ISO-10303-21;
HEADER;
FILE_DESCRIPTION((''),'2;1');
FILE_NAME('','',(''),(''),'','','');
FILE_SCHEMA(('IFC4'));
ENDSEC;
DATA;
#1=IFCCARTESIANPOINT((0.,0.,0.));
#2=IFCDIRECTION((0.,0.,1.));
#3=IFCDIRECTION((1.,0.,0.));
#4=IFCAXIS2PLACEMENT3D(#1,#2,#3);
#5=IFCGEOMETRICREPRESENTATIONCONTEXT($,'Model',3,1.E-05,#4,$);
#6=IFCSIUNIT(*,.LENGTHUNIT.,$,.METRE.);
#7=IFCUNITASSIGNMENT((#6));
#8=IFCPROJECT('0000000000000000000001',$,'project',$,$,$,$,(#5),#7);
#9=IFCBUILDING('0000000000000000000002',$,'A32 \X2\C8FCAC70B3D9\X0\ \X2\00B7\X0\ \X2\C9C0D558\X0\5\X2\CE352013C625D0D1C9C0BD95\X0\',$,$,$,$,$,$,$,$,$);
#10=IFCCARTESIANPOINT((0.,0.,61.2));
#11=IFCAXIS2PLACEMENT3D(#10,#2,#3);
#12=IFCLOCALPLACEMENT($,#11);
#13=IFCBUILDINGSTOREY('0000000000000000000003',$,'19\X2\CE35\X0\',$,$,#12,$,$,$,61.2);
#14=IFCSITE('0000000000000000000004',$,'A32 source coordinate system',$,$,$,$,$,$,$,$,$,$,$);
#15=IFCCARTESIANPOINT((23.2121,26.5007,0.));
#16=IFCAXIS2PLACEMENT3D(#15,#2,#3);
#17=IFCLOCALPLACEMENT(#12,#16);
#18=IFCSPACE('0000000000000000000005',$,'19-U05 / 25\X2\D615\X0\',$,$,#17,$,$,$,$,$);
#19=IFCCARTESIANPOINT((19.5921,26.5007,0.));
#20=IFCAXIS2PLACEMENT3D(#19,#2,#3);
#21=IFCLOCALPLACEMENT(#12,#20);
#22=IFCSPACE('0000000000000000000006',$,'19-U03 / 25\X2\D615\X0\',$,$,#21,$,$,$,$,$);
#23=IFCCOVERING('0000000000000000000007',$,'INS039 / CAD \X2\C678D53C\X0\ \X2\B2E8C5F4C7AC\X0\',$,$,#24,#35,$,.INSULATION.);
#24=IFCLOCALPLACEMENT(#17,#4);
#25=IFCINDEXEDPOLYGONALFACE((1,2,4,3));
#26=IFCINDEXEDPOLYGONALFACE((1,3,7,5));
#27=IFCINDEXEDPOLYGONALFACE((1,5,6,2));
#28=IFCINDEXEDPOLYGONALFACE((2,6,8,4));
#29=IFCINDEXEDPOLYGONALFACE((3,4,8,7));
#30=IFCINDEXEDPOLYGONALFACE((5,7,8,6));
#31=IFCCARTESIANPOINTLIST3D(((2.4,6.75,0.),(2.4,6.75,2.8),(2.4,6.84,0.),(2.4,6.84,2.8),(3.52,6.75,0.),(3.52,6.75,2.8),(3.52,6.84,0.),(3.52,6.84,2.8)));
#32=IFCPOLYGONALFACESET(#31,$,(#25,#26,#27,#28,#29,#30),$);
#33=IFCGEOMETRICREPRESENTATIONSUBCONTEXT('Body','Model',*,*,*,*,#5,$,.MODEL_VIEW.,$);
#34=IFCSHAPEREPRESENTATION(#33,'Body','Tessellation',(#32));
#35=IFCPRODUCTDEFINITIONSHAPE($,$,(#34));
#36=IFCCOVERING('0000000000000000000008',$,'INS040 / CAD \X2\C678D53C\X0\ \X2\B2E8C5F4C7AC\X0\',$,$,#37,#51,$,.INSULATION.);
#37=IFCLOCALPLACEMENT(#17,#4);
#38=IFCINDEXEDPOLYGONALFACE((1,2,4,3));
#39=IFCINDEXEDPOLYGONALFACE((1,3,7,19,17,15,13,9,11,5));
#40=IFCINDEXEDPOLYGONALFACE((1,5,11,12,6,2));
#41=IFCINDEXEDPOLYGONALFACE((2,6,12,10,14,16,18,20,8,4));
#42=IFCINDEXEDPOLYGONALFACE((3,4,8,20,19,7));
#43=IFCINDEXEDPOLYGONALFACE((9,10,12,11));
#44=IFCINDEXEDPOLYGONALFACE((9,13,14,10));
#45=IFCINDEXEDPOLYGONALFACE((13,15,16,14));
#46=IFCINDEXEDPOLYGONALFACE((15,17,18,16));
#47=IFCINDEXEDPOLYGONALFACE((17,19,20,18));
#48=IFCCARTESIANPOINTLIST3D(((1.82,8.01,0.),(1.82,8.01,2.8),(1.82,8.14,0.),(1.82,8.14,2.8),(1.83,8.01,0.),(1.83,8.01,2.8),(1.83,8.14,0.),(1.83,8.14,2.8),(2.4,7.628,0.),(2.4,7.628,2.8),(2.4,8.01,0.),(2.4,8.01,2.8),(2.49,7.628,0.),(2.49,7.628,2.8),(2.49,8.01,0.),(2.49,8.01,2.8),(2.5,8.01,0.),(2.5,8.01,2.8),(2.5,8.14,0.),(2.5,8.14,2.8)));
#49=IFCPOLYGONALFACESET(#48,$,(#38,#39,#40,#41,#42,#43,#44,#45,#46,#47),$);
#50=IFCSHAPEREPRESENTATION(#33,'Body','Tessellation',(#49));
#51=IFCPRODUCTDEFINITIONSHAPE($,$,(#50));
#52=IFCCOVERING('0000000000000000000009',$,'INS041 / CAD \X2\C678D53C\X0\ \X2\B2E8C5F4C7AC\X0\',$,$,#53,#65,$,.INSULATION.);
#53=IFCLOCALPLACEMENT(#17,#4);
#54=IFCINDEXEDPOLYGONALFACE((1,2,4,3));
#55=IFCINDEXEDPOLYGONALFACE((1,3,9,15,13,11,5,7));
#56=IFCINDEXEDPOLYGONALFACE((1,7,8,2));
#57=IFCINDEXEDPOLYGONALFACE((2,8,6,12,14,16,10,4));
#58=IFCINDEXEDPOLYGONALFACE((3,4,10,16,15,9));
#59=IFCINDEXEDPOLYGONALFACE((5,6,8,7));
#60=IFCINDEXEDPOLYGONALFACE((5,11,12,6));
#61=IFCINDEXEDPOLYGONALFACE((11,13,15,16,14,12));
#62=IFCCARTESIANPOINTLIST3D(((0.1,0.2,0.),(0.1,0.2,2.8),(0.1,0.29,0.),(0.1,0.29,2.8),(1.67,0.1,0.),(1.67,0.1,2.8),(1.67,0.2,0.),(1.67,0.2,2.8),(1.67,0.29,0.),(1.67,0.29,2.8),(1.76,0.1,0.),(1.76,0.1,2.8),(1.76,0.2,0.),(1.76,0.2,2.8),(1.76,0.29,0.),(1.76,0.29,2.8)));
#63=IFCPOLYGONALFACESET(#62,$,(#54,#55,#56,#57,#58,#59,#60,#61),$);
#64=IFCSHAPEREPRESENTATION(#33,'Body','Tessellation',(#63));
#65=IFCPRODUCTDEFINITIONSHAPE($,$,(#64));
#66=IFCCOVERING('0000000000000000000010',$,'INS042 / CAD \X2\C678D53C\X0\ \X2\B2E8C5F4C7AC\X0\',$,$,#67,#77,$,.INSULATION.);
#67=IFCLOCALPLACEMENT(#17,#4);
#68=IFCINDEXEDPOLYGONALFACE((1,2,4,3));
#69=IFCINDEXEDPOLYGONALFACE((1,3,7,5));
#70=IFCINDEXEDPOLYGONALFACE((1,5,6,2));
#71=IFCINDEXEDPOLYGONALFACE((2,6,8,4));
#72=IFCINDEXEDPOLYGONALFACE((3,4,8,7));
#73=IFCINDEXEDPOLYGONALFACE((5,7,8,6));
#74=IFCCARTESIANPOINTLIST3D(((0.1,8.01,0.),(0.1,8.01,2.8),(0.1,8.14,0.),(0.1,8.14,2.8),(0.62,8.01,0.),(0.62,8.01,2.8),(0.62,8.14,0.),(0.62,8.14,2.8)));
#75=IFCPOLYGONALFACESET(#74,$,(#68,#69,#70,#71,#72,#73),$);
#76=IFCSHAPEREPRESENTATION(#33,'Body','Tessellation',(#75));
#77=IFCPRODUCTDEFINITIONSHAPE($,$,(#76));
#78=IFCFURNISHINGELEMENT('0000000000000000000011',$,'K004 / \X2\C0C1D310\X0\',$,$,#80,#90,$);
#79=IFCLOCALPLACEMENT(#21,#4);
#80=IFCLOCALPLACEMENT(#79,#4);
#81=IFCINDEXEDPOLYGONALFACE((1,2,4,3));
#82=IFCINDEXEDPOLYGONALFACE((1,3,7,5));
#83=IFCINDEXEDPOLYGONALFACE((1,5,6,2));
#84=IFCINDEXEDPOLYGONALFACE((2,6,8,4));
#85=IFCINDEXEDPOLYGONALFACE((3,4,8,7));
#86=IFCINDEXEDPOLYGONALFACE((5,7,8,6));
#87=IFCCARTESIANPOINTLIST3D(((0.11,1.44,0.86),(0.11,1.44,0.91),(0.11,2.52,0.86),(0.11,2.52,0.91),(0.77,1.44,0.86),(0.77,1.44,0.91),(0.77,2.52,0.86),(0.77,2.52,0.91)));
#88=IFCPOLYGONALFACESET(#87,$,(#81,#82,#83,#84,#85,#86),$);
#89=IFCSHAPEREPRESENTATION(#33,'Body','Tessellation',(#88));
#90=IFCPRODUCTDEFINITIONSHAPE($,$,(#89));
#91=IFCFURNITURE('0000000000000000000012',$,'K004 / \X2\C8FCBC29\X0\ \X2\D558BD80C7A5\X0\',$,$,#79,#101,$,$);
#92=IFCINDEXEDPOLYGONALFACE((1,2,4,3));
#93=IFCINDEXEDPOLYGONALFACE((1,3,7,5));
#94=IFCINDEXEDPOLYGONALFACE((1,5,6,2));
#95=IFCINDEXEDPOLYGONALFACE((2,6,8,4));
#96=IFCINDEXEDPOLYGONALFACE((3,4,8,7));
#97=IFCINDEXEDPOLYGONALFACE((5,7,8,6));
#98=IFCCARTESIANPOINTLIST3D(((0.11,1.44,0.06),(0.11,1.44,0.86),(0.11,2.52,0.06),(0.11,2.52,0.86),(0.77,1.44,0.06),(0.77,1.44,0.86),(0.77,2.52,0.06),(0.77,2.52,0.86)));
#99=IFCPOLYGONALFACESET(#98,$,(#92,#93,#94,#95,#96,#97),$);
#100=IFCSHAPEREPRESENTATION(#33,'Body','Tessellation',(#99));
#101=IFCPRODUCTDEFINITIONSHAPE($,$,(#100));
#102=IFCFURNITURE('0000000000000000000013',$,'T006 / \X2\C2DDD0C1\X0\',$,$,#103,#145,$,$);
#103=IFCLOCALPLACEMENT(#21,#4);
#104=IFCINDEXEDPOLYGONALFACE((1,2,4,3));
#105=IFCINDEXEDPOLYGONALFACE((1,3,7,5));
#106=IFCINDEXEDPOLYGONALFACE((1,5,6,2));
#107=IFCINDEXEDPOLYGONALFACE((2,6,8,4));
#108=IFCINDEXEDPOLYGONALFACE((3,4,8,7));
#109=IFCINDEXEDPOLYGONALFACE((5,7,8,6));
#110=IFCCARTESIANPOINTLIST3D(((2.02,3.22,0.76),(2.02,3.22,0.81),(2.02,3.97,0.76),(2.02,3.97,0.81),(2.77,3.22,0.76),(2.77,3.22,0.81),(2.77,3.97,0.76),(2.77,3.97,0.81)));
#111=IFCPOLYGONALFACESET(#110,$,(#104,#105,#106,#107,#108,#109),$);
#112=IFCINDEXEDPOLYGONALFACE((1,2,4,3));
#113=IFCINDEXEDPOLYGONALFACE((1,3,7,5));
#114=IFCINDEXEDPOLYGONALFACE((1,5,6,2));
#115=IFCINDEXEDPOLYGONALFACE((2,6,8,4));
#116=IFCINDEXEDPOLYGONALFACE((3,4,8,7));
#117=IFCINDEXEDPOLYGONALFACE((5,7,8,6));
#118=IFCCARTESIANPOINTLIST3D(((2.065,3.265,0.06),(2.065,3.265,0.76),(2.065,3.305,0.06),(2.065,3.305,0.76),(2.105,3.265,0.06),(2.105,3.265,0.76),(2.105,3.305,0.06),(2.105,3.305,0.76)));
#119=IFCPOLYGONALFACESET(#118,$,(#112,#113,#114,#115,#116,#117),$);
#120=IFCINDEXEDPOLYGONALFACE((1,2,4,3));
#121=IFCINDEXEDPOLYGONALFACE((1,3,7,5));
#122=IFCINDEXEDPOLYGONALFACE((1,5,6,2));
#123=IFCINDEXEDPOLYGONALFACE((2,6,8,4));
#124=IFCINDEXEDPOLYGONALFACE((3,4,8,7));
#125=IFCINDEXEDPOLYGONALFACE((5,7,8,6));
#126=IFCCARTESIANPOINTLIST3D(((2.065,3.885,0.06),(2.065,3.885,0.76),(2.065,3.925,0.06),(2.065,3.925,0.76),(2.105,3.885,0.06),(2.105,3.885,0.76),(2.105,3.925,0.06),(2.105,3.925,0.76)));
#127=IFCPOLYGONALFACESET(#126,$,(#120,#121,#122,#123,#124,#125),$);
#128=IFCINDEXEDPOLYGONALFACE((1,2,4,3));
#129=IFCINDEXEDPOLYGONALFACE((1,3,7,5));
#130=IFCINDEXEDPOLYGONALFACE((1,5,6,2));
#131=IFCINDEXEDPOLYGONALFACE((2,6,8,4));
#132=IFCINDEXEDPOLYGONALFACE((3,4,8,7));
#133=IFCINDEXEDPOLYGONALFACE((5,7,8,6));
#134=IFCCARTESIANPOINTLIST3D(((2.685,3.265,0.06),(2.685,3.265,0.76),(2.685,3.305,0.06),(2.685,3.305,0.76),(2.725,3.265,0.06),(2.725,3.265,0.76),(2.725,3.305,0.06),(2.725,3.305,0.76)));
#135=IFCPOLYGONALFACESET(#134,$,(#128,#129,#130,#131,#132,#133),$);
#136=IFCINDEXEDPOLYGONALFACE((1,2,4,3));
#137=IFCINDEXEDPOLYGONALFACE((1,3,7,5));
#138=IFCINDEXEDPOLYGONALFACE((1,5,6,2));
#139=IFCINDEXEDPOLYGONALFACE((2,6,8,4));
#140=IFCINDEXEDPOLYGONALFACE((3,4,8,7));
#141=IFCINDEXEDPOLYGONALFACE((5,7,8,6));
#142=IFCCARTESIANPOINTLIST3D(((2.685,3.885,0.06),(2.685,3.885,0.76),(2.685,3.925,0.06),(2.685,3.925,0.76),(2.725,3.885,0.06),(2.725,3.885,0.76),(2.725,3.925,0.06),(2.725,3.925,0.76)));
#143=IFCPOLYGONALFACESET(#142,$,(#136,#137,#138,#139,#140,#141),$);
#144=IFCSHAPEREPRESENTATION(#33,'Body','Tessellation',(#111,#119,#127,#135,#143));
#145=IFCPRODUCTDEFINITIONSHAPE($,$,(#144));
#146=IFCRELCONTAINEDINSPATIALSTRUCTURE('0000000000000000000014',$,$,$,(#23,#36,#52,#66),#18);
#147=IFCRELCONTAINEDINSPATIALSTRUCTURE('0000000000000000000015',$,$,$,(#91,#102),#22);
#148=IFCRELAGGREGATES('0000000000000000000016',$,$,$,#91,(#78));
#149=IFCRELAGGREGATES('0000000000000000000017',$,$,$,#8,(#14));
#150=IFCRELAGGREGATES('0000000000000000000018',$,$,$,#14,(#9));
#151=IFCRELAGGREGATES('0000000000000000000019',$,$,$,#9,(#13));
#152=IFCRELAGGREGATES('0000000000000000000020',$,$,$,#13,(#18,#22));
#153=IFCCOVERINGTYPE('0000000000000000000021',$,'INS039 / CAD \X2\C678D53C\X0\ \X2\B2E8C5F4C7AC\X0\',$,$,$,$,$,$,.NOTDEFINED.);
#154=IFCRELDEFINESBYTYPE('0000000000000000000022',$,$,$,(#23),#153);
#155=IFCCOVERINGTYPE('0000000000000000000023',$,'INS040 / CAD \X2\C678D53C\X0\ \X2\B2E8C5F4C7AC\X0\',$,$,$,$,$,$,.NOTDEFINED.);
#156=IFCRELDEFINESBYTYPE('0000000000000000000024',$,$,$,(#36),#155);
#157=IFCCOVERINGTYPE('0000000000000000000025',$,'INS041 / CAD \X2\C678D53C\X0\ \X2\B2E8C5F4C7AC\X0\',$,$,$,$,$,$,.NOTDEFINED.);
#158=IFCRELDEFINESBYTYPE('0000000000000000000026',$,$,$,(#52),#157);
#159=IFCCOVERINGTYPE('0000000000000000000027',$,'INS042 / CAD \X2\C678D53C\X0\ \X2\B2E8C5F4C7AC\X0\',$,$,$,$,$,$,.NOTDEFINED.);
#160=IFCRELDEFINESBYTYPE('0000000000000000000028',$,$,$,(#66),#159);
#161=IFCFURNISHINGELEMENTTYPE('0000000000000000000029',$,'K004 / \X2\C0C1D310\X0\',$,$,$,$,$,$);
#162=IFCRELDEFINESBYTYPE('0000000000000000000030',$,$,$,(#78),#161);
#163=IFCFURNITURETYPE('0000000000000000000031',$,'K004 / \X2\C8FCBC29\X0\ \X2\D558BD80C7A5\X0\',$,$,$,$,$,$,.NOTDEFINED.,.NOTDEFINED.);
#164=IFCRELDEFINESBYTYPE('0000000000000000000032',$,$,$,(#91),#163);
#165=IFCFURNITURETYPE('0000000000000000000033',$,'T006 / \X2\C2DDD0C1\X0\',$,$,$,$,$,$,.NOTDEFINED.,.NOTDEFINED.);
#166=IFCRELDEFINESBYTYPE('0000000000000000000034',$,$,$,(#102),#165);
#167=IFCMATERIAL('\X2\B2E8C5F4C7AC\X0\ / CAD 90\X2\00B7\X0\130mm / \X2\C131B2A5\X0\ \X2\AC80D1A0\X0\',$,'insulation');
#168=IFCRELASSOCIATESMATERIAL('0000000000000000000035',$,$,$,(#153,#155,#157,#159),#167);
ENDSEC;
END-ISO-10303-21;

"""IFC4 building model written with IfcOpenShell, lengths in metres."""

from ifc_helpers import new_model, si_unit, frame, origin, origin_with_axes, place, context, subcontext, project, spatial, polyline, outline, extrude, source, transform, mapped, material, type_object, type_shapes, element, aggregate, save


model = new_model("IFC4")

# Units and contexts
model_context = context("Model", 3, precision=1e-05, world=origin_with_axes())
body_context = subcontext(model_context, "Body", "Model", "MODEL_VIEW")
ifc_project = project(units=[si_unit("LENGTHUNIT", "METRE")], contexts=[model_context])

# Site, building, storey, space
storey_placement = place(None, frame((0.0, 0.0, 61.2), z_axis=(0.0, 0.0, 1.0), x_axis=(1.0, 0.0, 0.0)))
space_1_placement = place(storey_placement, frame((23.2121, 26.5007, 0.0), z_axis=(0.0, 0.0, 1.0), x_axis=(1.0, 0.0, 0.0)))
site = spatial("IfcSite", under=ifc_project, Name="A32 source coordinate system")
building = spatial("IfcBuilding", under=site, Name="A32 주거동 · 지하5층–옥탑지붕")
storey = spatial("IfcBuildingStorey", under=building, at=storey_placement, Name="19층", Elevation=61.2)
space_1 = spatial("IfcSpace", under=storey, at=space_1_placement, Name="19-U05 / 25형")

# Shared definitions
space_2_placement = place(storey_placement, frame((19.5921, 26.5007, 0.0), z_axis=(0.0, 0.0, 1.0), x_axis=(1.0, 0.0, 0.0)))
space_2 = spatial("IfcSpace", under=storey, at=space_2_placement, Name="19-U03 / 25형")

# Coverings
ifc_material = material(Name="단열재 / CAD 90·130mm / 성능 검토", Category="insulation")
covering_type_1 = type_object("IfcCoveringType", Name="INS039 / CAD 외피 단열재", PredefinedType="NOTDEFINED", material=ifc_material)
shared_shape_1 = source(origin(), body_context, "Body", "SweptSolid", [
    extrude(outline(polyline([(2.4, 6.75), (2.4, 6.84), (3.52, 6.84), (3.52, 6.75), (2.4, 6.75)])), origin(), (0.0, 0.0, 1.0), 2.8),
])
type_shapes(covering_type_1, [shared_shape_1])
covering_1_placement = place(space_1_placement, origin_with_axes())
element("IfcCovering", 1, at=covering_1_placement, inside=space_1, type_object=covering_type_1, Name="INS039 / CAD 외피 단열재", PredefinedType="INSULATION", context=body_context, shape_type="MappedRepresentation", body=[
    mapped(shared_shape_1, transform((0.0, 0.0, 0.0), scale=1.0)),
])
covering_type_2 = type_object("IfcCoveringType", Name="INS040 / CAD 외피 단열재", PredefinedType="NOTDEFINED", material=ifc_material)
shared_shape_2 = source(origin(), body_context, "Body", "SweptSolid", [
    extrude(outline(polyline([(2.4, 7.628), (2.4, 8.01), (1.83, 8.01), (1.82, 8.01), (1.82, 8.14), (1.83, 8.14), (2.5, 8.14), (2.5, 8.01), (2.49, 8.01), (2.49, 7.628), (2.4, 7.628)])), origin(), (0.0, 0.0, 1.0), 2.8),
])
type_shapes(covering_type_2, [shared_shape_2])
covering_2_placement = place(space_1_placement, origin_with_axes())
element("IfcCovering", 2, at=covering_2_placement, inside=space_1, type_object=covering_type_2, Name="INS040 / CAD 외피 단열재", PredefinedType="INSULATION", context=body_context, shape_type="MappedRepresentation", body=[
    mapped(shared_shape_2, transform((0.0, 0.0, 0.0), scale=1.0)),
])
covering_type_3 = type_object("IfcCoveringType", Name="INS041 / CAD 외피 단열재", PredefinedType="NOTDEFINED", material=ifc_material)
shared_shape_3 = source(origin(), body_context, "Body", "SweptSolid", [
    extrude(outline(polyline([(1.67, 0.2), (0.1, 0.2), (0.1, 0.29), (1.67, 0.29), (1.76, 0.29), (1.76, 0.2), (1.76, 0.1), (1.67, 0.1), (1.67, 0.2)])), origin(), (0.0, 0.0, 1.0), 2.8),
])
type_shapes(covering_type_3, [shared_shape_3])
covering_3_placement = place(space_1_placement, origin_with_axes())
element("IfcCovering", 3, at=covering_3_placement, inside=space_1, type_object=covering_type_3, Name="INS041 / CAD 외피 단열재", PredefinedType="INSULATION", context=body_context, shape_type="MappedRepresentation", body=[
    mapped(shared_shape_3, transform((0.0, 0.0, 0.0), scale=1.0)),
])
covering_type_4 = type_object("IfcCoveringType", Name="INS042 / CAD 외피 단열재", PredefinedType="NOTDEFINED", material=ifc_material)
shared_shape_4 = source(origin(), body_context, "Body", "SweptSolid", [
    extrude(outline(polyline([(0.62, 8.14), (0.62, 8.01), (0.1, 8.01), (0.1, 8.14), (0.62, 8.14)])), origin(), (0.0, 0.0, 1.0), 2.8),
])
type_shapes(covering_type_4, [shared_shape_4])
covering_4_placement = place(space_1_placement, origin_with_axes())
element("IfcCovering", 4, at=covering_4_placement, inside=space_1, type_object=covering_type_4, Name="INS042 / CAD 외피 단열재", PredefinedType="INSULATION", context=body_context, shape_type="MappedRepresentation", body=[
    mapped(shared_shape_4, transform((0.0, 0.0, 0.0), scale=1.0)),
])

# Furnishing element
furnishing_element_type_1 = type_object("IfcFurnishingElementType", Name="K004 / 상판")
shared_shape_5 = source(origin(), body_context, "Body", "SweptSolid", [
    extrude(outline(polyline([(0.77, 2.52), (0.77, 1.44), (0.11, 1.44), (0.11, 2.52), (0.77, 2.52)])), frame((0.0, 0.0, 0.86)), (0.0, 0.0, 1.0), 0.05),
])
type_shapes(furnishing_element_type_1, [shared_shape_5])
furniture_1_placement = place(space_2_placement, origin_with_axes())
furnishing_1_placement = place(furniture_1_placement, origin_with_axes())
furnishing_1 = element("IfcFurnishingElement", 5, at=furnishing_1_placement, type_object=furnishing_element_type_1, Name="K004 / 상판", context=body_context, shape_type="MappedRepresentation", body=[
    mapped(shared_shape_5, transform((0.0, 0.0, 0.0), scale=1.0)),
])

# Furniture
furniture_type_1 = type_object("IfcFurnitureType", Name="K004 / 주방 하부장", AssemblyPlace="NOTDEFINED", PredefinedType="NOTDEFINED")
shared_shape_6 = source(origin(), body_context, "Body", "SweptSolid", [
    extrude(outline(polyline([(0.11, 2.52), (0.77, 2.52), (0.77, 1.44), (0.11, 1.44), (0.11, 2.52)])), frame((0.0, 0.0, 0.06)), (0.0, 0.0, 1.0), 0.8),
])
type_shapes(furniture_type_1, [shared_shape_6])
furniture_1 = element("IfcFurniture", 6, at=furniture_1_placement, inside=space_2, type_object=furniture_type_1, Name="K004 / 주방 하부장", context=body_context, shape_type="MappedRepresentation", body=[
    mapped(shared_shape_6, transform((0.0, 0.0, 0.0), scale=1.0)),
])
aggregate(furniture_1, [furnishing_1])
furniture_type_2 = type_object("IfcFurnitureType", Name="T006 / 식탁", AssemblyPlace="NOTDEFINED", PredefinedType="NOTDEFINED")
shared_shape_7 = source(origin(), body_context, "Body", "SweptSolid", [
    extrude(outline(polyline([(2.77, 3.22), (2.02, 3.22), (2.02, 3.97), (2.77, 3.97), (2.77, 3.22)])), frame((0.0, 0.0, 0.76)), (0.0, 0.0, 1.0), 0.05),
    extrude(outline(polyline([(2.065, 3.265), (2.065, 3.305), (2.105, 3.305), (2.105, 3.265), (2.065, 3.265)])), frame((0.0, 0.0, 0.06)), (0.0, 0.0, 1.0), 0.7),
    extrude(outline(polyline([(2.065, 3.885), (2.065, 3.925), (2.105, 3.925), (2.105, 3.885), (2.065, 3.885)])), frame((0.0, 0.0, 0.06)), (0.0, 0.0, 1.0), 0.7),
    extrude(outline(polyline([(2.685, 3.265), (2.685, 3.305), (2.725, 3.305), (2.725, 3.265), (2.685, 3.265)])), frame((0.0, 0.0, 0.06)), (0.0, 0.0, 1.0), 0.7),
    extrude(outline(polyline([(2.685, 3.885), (2.685, 3.925), (2.725, 3.925), (2.725, 3.885), (2.685, 3.885)])), frame((0.0, 0.0, 0.06)), (0.0, 0.0, 1.0), 0.7),
])
type_shapes(furniture_type_2, [shared_shape_7])
furniture_2_placement = place(space_2_placement, origin_with_axes())
element("IfcFurniture", 7, at=furniture_2_placement, inside=space_2, type_object=furniture_type_2, Name="T006 / 식탁", context=body_context, shape_type="MappedRepresentation", body=[
    mapped(shared_shape_7, transform((0.0, 0.0, 0.0), scale=1.0)),
])

save(model, "model.ifc")
